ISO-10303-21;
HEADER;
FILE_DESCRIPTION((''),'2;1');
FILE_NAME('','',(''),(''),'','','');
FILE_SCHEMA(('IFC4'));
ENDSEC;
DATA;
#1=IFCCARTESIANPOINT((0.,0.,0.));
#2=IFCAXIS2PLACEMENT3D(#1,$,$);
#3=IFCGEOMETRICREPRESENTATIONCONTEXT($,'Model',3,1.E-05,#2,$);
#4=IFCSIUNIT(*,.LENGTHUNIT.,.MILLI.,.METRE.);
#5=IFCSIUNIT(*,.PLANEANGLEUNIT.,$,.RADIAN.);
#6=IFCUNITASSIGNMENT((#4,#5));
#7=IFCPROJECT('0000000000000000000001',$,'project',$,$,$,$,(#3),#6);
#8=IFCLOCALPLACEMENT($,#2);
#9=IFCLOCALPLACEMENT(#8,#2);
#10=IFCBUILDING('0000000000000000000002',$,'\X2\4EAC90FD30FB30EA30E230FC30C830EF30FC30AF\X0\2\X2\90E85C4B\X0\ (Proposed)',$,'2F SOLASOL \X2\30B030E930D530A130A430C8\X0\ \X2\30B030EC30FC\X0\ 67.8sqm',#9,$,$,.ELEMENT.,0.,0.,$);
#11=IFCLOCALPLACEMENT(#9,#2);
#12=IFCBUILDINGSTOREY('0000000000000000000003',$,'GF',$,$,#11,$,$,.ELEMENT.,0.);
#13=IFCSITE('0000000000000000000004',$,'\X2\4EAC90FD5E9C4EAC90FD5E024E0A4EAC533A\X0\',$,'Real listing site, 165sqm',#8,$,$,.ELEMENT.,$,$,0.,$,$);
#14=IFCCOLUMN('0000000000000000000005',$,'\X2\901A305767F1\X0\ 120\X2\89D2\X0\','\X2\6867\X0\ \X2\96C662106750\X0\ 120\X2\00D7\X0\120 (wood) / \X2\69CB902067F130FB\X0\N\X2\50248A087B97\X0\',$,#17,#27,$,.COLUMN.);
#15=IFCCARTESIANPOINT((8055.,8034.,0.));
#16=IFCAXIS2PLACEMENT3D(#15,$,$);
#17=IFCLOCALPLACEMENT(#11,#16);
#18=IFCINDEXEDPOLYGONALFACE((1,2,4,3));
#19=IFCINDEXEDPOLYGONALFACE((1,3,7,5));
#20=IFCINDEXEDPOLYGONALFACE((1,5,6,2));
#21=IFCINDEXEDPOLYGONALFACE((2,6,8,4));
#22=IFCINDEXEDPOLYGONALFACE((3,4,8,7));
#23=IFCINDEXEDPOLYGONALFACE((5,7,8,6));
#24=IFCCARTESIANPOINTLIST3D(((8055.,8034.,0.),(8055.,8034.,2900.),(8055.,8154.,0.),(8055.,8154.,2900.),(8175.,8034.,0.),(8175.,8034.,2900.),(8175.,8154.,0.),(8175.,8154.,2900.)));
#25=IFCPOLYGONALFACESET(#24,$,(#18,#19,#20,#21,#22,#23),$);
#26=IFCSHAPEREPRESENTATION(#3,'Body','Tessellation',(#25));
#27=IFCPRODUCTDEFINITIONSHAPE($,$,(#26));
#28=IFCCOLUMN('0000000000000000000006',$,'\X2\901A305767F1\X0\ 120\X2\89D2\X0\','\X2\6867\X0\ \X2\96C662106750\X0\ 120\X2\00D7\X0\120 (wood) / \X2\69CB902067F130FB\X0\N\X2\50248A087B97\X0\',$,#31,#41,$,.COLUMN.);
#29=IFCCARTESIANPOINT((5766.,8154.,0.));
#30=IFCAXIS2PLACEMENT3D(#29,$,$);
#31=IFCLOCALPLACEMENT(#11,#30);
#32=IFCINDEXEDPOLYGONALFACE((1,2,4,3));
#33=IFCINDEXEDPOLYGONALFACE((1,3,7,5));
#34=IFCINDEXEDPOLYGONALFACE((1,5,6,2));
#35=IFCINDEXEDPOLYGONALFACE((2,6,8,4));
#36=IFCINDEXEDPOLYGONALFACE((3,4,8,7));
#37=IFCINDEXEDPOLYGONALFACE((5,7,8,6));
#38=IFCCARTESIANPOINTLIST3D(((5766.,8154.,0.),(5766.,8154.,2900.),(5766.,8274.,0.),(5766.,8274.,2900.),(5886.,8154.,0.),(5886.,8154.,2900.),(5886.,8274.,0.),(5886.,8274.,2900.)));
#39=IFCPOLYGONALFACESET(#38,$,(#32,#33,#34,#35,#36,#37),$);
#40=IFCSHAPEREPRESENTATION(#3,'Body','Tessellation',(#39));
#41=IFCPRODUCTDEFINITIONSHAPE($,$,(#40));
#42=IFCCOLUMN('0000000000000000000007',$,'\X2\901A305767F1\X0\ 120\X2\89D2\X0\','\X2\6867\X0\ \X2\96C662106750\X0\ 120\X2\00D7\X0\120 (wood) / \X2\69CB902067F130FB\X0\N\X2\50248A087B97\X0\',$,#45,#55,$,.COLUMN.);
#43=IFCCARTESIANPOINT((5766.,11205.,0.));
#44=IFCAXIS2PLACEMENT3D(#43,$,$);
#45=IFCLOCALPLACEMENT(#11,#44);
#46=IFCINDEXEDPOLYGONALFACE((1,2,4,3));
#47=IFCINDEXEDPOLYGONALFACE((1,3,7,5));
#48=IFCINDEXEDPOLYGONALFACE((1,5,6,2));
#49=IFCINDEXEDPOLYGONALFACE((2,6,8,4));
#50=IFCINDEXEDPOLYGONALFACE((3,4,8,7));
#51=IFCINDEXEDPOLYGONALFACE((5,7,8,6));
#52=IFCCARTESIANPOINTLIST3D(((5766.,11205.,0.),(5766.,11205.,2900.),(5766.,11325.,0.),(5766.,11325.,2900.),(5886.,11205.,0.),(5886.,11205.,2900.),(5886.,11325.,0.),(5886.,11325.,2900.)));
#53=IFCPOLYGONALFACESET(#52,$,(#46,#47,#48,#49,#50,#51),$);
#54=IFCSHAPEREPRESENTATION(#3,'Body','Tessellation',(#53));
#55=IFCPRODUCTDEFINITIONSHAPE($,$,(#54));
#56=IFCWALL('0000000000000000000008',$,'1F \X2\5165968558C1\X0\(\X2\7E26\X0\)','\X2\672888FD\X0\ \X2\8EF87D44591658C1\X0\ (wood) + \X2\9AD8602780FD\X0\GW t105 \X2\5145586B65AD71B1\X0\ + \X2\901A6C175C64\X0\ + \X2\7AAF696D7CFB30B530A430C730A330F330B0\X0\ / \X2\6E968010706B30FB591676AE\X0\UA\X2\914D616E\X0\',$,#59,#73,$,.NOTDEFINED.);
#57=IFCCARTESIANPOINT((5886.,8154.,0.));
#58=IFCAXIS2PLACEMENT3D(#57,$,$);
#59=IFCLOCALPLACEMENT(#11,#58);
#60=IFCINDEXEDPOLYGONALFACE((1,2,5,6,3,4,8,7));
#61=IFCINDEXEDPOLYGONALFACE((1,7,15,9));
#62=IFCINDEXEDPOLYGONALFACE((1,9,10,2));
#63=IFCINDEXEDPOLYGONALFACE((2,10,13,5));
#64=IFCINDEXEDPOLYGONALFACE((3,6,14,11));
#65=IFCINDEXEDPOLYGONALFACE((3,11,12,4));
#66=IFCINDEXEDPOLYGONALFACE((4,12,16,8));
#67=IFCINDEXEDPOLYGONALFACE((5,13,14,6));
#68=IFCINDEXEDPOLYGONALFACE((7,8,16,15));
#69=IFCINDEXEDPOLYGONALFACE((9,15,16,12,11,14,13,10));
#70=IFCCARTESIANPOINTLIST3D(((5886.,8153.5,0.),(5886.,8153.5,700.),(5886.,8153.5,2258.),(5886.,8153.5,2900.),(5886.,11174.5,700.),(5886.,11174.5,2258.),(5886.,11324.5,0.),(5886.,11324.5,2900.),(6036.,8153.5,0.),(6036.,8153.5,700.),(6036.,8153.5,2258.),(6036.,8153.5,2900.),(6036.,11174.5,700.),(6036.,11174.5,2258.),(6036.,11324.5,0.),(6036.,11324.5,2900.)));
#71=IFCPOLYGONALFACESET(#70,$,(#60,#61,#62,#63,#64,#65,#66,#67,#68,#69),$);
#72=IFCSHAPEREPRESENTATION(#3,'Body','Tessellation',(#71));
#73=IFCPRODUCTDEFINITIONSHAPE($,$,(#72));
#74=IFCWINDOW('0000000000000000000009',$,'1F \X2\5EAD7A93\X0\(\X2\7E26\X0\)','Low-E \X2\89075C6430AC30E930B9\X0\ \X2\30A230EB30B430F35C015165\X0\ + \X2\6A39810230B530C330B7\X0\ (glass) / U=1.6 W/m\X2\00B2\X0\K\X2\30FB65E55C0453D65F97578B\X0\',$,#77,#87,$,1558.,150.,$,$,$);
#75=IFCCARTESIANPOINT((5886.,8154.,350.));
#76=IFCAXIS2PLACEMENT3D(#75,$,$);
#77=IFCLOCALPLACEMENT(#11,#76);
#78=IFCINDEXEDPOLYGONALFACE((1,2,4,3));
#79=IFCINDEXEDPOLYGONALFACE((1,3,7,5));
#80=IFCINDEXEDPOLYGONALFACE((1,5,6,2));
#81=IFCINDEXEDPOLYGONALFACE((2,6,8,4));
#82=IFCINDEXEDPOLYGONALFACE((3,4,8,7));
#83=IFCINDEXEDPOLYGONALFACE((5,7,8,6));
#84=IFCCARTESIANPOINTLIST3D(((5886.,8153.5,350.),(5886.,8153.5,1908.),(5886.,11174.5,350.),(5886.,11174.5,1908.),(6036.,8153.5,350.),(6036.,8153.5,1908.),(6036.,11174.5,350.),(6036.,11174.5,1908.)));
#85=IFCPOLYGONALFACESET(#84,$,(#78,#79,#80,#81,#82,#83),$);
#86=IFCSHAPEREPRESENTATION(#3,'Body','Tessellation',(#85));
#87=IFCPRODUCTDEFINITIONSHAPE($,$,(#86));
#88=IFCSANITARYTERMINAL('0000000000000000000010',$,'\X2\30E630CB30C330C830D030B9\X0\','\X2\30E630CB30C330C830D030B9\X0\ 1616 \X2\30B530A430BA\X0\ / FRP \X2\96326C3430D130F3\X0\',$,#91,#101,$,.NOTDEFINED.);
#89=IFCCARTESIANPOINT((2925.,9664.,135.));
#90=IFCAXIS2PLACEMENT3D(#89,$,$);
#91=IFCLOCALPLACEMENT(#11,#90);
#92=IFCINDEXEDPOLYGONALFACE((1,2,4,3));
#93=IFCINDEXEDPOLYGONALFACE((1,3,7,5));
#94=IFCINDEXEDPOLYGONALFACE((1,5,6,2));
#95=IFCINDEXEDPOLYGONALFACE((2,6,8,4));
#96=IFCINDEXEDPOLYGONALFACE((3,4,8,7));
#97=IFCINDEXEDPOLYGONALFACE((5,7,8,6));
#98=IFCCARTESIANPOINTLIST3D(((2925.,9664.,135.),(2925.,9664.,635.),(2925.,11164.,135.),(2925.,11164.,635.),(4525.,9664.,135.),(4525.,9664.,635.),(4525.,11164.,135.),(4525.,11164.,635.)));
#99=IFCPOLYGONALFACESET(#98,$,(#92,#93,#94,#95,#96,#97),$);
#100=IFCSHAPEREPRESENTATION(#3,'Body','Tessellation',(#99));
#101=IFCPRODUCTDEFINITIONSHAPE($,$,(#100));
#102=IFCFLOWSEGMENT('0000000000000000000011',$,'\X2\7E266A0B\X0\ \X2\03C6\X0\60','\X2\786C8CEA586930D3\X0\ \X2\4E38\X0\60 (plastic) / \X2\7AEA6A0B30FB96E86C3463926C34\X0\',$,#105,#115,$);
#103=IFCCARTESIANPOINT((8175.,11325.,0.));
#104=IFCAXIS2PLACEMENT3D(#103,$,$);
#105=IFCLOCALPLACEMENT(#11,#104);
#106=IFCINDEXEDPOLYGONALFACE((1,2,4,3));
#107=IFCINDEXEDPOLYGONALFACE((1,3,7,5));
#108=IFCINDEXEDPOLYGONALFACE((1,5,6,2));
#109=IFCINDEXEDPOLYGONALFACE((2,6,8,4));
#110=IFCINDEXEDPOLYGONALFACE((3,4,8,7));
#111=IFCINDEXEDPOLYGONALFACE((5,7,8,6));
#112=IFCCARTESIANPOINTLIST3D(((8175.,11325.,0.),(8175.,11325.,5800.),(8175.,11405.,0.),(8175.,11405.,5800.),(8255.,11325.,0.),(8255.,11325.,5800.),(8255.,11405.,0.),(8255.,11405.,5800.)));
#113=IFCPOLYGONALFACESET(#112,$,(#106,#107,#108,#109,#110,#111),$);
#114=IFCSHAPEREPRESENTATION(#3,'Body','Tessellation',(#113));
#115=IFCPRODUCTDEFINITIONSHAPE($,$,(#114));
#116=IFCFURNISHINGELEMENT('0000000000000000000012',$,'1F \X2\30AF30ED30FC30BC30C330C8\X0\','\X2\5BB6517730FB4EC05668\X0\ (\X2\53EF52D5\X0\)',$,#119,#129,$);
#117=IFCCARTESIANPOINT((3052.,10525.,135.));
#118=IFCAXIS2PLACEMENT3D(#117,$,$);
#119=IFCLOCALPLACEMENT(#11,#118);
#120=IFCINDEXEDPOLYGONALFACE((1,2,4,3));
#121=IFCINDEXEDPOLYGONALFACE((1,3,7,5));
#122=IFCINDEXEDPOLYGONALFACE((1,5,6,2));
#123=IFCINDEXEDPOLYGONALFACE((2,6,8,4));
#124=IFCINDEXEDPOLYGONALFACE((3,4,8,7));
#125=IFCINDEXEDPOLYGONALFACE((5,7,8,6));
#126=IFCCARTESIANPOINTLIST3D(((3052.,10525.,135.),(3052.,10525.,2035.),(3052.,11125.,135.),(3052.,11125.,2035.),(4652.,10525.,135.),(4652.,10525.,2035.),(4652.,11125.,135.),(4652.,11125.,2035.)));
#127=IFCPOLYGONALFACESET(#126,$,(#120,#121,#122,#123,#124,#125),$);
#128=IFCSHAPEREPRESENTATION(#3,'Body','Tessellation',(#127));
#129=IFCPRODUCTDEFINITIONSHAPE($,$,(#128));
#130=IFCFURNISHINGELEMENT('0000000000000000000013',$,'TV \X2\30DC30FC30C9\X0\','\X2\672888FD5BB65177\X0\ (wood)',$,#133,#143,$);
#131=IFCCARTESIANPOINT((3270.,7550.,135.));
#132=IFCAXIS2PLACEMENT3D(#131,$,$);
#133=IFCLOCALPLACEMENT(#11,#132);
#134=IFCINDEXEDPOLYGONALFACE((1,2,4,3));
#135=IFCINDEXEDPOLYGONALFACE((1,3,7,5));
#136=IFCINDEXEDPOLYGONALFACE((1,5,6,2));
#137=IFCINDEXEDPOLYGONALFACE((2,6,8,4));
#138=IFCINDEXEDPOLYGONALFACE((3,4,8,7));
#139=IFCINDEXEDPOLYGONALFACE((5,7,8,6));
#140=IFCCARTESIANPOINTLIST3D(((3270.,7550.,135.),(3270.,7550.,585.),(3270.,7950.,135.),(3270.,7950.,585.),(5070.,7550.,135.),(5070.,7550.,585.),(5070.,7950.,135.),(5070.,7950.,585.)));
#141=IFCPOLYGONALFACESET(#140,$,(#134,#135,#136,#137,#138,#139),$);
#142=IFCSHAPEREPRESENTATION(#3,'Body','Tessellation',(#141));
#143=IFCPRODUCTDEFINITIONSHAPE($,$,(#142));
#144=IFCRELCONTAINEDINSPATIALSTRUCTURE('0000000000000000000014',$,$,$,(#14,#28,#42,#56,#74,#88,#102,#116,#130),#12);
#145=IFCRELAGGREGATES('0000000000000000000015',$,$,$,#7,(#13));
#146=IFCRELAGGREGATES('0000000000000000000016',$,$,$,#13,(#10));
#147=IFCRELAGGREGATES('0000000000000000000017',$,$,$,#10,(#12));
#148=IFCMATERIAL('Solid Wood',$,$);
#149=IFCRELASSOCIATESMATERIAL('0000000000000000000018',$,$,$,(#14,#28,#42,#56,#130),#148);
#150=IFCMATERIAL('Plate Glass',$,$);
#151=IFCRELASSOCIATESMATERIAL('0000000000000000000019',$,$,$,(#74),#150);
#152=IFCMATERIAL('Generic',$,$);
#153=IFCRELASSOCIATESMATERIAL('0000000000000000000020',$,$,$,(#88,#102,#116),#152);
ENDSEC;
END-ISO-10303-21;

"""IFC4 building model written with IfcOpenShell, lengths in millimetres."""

from ifc_helpers import new_model, si_unit, frame, frame_2d, origin, place, context, project, spatial, rectangle, extrude, material, element, fill, save


model = new_model("IFC4")

# Units and contexts
model_context = context("Model", 3, precision=1e-05, world=origin())
ifc_project = project(units=[si_unit("LENGTHUNIT", "METRE", prefix="MILLI"), si_unit("PLANEANGLEUNIT", "RADIAN")], contexts=[model_context])

# Site, building, storey
site_placement = place(None, origin())
site = spatial("IfcSite", under=ifc_project, at=site_placement, Name="京都府京都市上京区", ObjectType="Real listing site, 165sqm", CompositionType="ELEMENT", RefElevation=0.0)
building_placement = place(site_placement, origin())
building = spatial("IfcBuilding", under=site, at=building_placement, Name="京都・リモートワーク2部屋 (Proposed)", ObjectType="2F SOLASOL グラファイト グレー 67.8sqm", CompositionType="ELEMENT", ElevationOfRefHeight=0.0, ElevationOfTerrain=0.0)
storey_placement = place(building_placement, origin())
storey = spatial("IfcBuildingStorey", under=building, at=storey_placement, Name="GF", CompositionType="ELEMENT", Elevation=0.0)

# Columns
ifc_material_1 = material(Name="Solid Wood")
column_1_placement = place(storey_placement, frame((8055.0, 8034.0, 0.0)))
element("IfcColumn", 1, at=column_1_placement, inside=storey, material=ifc_material_1, Name="通し柱 120角", Description="桧 集成材 120×120 (wood) / 構造柱・N値計算", PredefinedType="COLUMN", context=model_context, shape_type="SweptSolid", body=[
    extrude(rectangle(XDim=120.0, YDim=120.0, at=frame_2d((60.0, 60.0))), frame((8055.0, 8034.0, 0.0)), (0.0, 0.0, 1.0), 2900.0),
])
column_2_placement = place(storey_placement, frame((5766.0, 8154.0, 0.0)))
element("IfcColumn", 2, at=column_2_placement, inside=storey, material=ifc_material_1, Name="通し柱 120角", Description="桧 集成材 120×120 (wood) / 構造柱・N値計算", PredefinedType="COLUMN", context=model_context, shape_type="SweptSolid", body=[
    extrude(rectangle(XDim=120.0, YDim=120.0, at=frame_2d((60.0, 60.0))), frame((5766.0, 8154.0, 0.0)), (0.0, 0.0, 1.0), 2900.0),
])
column_3_placement = place(storey_placement, frame((5766.0, 11205.0, 0.0)))
element("IfcColumn", 3, at=column_3_placement, inside=storey, material=ifc_material_1, Name="通し柱 120角", Description="桧 集成材 120×120 (wood) / 構造柱・N値計算", PredefinedType="COLUMN", context=model_context, shape_type="SweptSolid", body=[
    extrude(rectangle(XDim=120.0, YDim=120.0, at=frame_2d((60.0, 60.0))), frame((5766.0, 11205.0, 0.0)), (0.0, 0.0, 1.0), 2900.0),
])

# Wall, opening, window
wall_1_placement = place(storey_placement, frame((5886.0, 8154.0, 0.0)))
wall_1 = element("IfcWall", 4, at=wall_1_placement, inside=storey, material=ifc_material_1, Name="1F 入隅壁(縦)", Description="木製 軸組外壁 (wood) + 高性能GW t105 充填断熱 + 通気層 + 窯業系サイディング / 準耐火・外皮UA配慮", PredefinedType="NOTDEFINED", context=model_context, shape_type="SweptSolid", body=[
    extrude(rectangle(XDim=150.0, YDim=3171.0, at=frame_2d((75.0, 1585.0))), frame((5886.0, 8154.0, 0.0)), (0.0, 0.0, 1.0), 2900.0),
])
opening_placement = place(storey_placement, frame((5886.0, 8154.0, 350.0)))
opening = element("IfcOpeningElement", 5, at=opening_placement, cuts=wall_1, PredefinedType="NOTDEFINED", context=model_context, shape_type="SweptSolid", body=[
    extrude(rectangle(XDim=150.0, YDim=3021.0, at=frame_2d((75.0, 1510.0))), frame((5886.0, 8154.0, 350.0)), (0.0, 0.0, 1.0), 1558.0),
])
ifc_material_2 = material(Name="Plate Glass")
window_placement = place(storey_placement, frame((5886.0, 8154.0, 350.0)))
window = element("IfcWindow", 6, at=window_placement, inside=storey, material=ifc_material_2, Name="1F 庭窓(縦)", Description="Low-E 複層ガラス アルゴン封入 + 樹脂サッシ (glass) / U=1.6 W/m²K・日射取得型", OverallHeight=1558.0, OverallWidth=150.0, context=model_context, shape_type="SweptSolid", body=[
    extrude(rectangle(XDim=150.0, YDim=3021.0, at=frame_2d((75.0, 1510.0))), frame((5886.0, 8154.0, 350.0)), (0.0, 0.0, 1.0), 1558.0),
])
fill(opening, window)

# Sanitary terminal
ifc_material_3 = material(Name="Generic")
sanitary_terminal_placement = place(storey_placement, frame((2925.0, 9664.0, 135.0)))
element("IfcSanitaryTerminal", 7, at=sanitary_terminal_placement, inside=storey, material=ifc_material_3, Name="ユニットバス", Description="ユニットバス 1616 サイズ / FRP 防水パン", PredefinedType="NOTDEFINED", context=model_context, shape_type="SweptSolid", body=[
    extrude(rectangle(XDim=1600.0, YDim=1500.0, at=frame_2d((800.0, 750.0))), frame((2925.0, 9664.0, 135.0)), (0.0, 0.0, 1.0), 500.0),
])

# Flow segment
flow_segment_placement = place(storey_placement, frame((8175.0, 11325.0, 0.0)))
element("IfcFlowSegment", 8, at=flow_segment_placement, inside=storey, material=ifc_material_3, Name="縦樋 φ60", Description="硬質塩ビ 丸60 (plastic) / 竪樋・雨水排水", context=model_context, shape_type="SweptSolid", body=[
    extrude(rectangle(XDim=80.0, YDim=80.0, at=frame_2d((40.0, 40.0))), frame((8175.0, 11325.0, 0.0)), (0.0, 0.0, 1.0), 5800.0),
])

# Furnishing elements
furnishing_1_placement = place(storey_placement, frame((3052.0, 10525.0, 135.0)))
element("IfcFurnishingElement", 9, at=furnishing_1_placement, inside=storey, material=ifc_material_3, Name="1F クローゼット", Description="家具・什器 (可動)", context=model_context, shape_type="SweptSolid", body=[
    extrude(rectangle(XDim=1600.0, YDim=600.0, at=frame_2d((800.0, 300.0))), frame((3052.0, 10525.0, 135.0)), (0.0, 0.0, 1.0), 1900.0),
])
furnishing_2_placement = place(storey_placement, frame((3270.0, 7550.0, 135.0)))
element("IfcFurnishingElement", 10, at=furnishing_2_placement, inside=storey, material=ifc_material_1, Name="TV ボード", Description="木製家具 (wood)", context=model_context, shape_type="SweptSolid", body=[
    extrude(rectangle(XDim=1800.0, YDim=400.0, at=frame_2d((900.0, 200.0))), frame((3270.0, 7550.0, 135.0)), (0.0, 0.0, 1.0), 450.0),
])

save(model, "model.ifc")
